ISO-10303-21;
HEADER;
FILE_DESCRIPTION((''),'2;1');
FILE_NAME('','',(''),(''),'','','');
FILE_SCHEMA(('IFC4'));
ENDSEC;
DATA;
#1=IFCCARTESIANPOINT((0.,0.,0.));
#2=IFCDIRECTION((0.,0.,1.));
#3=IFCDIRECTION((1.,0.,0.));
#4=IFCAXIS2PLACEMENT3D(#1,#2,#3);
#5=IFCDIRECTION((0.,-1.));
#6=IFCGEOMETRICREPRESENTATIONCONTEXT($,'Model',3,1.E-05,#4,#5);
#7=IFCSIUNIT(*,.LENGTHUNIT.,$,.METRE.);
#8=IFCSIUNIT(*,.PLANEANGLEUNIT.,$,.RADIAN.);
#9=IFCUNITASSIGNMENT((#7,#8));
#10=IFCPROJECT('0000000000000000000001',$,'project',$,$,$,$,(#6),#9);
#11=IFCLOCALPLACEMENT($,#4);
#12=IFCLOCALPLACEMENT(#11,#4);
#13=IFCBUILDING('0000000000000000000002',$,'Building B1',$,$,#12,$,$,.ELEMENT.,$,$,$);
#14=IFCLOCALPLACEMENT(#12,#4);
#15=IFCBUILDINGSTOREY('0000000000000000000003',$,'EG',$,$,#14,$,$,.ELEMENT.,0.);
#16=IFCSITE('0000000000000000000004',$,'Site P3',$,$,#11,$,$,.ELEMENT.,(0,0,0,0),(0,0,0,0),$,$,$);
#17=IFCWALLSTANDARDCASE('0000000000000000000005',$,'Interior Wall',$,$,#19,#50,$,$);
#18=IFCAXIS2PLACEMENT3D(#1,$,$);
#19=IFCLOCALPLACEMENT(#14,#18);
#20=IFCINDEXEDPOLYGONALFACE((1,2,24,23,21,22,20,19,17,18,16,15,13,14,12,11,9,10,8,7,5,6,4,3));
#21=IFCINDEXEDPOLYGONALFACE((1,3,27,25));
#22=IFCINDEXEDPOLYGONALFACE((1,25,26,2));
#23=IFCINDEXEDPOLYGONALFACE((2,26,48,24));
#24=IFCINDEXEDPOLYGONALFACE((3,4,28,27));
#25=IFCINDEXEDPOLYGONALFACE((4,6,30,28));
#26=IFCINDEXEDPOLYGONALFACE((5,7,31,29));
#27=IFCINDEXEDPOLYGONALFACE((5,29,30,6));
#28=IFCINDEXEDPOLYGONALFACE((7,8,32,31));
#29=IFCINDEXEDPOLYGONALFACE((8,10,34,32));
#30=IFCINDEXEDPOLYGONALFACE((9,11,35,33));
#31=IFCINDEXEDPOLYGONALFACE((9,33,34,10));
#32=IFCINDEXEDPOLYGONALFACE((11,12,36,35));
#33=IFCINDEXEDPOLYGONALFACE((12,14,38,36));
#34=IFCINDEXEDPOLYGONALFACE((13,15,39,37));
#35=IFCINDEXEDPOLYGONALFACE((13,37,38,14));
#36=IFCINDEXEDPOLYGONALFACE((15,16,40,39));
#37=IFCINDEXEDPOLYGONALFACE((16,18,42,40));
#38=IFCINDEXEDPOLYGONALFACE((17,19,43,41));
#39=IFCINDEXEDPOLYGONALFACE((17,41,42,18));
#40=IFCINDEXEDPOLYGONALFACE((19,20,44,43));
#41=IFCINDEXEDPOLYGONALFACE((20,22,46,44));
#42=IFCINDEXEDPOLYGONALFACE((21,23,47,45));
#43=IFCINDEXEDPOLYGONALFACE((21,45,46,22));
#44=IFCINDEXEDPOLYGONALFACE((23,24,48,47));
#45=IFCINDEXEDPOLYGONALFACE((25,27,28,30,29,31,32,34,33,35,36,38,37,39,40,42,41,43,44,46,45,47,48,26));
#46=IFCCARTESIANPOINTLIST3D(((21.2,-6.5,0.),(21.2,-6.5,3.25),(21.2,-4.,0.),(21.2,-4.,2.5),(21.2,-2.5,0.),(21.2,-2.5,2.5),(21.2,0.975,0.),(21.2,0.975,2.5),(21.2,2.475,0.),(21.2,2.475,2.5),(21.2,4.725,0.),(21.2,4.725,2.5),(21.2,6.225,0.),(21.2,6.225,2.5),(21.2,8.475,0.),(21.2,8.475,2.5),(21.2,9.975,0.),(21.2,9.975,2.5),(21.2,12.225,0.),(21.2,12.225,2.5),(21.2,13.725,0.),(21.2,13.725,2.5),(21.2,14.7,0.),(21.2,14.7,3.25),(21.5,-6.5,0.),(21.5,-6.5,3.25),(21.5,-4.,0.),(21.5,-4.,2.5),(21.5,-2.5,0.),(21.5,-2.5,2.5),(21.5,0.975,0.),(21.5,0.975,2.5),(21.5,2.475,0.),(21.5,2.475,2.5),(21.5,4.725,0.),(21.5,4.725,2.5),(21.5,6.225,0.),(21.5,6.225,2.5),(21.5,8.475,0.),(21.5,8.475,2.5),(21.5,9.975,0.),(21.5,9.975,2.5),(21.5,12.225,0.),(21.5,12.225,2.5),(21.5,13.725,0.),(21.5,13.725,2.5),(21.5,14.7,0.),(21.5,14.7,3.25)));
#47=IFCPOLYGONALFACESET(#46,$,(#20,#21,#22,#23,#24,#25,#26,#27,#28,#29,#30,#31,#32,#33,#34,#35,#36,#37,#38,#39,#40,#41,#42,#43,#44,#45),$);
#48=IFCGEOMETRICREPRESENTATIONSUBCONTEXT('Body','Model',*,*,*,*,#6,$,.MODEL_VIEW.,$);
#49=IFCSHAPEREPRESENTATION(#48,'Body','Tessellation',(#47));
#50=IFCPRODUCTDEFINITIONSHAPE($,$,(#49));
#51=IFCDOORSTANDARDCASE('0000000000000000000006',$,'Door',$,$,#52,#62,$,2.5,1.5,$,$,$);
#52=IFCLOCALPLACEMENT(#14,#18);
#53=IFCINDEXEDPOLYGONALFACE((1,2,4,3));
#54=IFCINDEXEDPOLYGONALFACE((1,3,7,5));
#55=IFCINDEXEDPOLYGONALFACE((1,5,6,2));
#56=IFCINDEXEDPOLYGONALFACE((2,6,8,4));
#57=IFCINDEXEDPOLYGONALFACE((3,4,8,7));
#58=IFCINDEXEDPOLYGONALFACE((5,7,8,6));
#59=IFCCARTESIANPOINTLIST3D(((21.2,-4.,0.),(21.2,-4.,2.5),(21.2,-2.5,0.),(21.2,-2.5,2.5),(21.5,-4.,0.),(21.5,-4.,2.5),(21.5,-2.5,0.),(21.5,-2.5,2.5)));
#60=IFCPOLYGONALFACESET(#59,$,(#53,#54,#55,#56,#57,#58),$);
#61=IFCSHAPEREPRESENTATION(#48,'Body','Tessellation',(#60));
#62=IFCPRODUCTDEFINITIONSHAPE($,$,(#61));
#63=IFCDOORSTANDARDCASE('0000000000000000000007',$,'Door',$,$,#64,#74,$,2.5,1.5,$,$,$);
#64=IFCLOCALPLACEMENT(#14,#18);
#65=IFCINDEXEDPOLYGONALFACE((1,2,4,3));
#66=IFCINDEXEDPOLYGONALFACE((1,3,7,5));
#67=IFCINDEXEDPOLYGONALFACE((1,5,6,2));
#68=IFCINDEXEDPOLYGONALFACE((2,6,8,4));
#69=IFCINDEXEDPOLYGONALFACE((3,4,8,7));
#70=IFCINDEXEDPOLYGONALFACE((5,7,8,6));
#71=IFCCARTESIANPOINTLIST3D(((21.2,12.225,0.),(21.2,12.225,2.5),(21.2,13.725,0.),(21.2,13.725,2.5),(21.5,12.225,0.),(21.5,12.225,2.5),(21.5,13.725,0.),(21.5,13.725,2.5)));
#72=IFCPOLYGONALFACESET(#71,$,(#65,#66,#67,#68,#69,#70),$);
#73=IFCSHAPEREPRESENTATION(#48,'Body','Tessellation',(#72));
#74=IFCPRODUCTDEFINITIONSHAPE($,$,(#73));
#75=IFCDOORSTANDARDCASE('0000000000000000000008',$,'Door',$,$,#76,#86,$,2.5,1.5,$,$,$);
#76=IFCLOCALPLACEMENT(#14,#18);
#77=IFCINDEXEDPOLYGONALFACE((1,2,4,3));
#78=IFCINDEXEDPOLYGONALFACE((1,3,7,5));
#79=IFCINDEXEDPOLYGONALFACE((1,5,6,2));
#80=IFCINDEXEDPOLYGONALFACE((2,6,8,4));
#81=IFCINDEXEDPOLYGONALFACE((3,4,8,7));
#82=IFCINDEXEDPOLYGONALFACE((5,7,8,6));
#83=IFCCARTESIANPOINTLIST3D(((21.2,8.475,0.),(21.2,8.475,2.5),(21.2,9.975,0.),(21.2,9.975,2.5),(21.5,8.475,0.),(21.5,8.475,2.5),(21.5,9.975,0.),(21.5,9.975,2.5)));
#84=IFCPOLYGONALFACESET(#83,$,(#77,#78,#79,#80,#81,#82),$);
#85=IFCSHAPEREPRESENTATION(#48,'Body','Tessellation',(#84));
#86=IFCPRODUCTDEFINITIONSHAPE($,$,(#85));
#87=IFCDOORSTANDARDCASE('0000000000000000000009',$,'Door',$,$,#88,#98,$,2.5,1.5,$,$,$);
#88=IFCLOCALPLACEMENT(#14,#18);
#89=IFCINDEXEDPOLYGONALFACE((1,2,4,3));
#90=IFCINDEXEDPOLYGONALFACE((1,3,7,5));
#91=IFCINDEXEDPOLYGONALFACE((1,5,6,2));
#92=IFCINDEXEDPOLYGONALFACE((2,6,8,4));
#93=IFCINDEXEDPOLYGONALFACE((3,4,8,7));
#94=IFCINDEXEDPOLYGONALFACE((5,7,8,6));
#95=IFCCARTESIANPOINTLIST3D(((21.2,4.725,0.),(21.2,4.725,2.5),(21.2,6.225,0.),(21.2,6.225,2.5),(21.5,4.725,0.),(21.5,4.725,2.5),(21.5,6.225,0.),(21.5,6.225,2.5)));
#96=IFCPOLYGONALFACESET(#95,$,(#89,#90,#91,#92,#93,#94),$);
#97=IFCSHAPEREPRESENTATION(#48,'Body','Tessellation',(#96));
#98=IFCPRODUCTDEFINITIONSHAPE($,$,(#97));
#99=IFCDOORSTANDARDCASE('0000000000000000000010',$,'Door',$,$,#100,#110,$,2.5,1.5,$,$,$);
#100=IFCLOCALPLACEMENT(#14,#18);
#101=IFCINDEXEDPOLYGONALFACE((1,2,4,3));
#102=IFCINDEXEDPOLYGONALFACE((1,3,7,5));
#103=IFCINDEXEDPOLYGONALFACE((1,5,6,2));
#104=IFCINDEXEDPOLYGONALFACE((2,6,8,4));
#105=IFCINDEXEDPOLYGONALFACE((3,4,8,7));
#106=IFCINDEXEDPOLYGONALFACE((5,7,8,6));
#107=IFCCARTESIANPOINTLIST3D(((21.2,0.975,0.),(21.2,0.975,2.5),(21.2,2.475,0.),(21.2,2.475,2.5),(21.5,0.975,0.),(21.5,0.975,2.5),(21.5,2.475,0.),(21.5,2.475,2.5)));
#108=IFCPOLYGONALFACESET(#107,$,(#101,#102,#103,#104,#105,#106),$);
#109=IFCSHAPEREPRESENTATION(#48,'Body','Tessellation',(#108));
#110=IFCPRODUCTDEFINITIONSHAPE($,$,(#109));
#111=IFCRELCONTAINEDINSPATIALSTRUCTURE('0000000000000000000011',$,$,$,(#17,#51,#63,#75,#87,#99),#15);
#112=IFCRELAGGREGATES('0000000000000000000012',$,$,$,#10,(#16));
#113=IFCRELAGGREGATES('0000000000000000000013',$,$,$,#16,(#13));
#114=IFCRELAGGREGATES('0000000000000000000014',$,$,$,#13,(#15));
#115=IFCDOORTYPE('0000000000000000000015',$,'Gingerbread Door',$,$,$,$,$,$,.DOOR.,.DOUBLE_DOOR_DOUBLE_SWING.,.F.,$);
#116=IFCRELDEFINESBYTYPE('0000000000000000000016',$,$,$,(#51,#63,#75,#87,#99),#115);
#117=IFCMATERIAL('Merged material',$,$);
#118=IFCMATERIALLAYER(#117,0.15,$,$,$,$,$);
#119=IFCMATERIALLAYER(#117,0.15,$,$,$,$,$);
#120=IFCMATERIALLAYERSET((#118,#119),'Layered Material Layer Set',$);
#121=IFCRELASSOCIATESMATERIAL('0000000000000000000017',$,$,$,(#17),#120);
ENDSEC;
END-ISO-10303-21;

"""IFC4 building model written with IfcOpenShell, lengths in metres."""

from ifc_helpers import new_model, si_unit, direction, frame, origin_with_axes, place, context, subcontext, project, spatial, polyline, outline, extrude, source, transform, mapped, material, layer, layer_set, layer_usage, type_object, element, fill, save


model = new_model("IFC4")

# Units and contexts
model_context = context("Model", 3, precision=1e-05, world=origin_with_axes(), true_north=direction((0.0, -1.0)))
body_context = subcontext(model_context, "Body", "Model", "MODEL_VIEW")
ifc_project = project(units=[si_unit("LENGTHUNIT", "METRE"), si_unit("PLANEANGLEUNIT", "RADIAN")], contexts=[model_context])

# Site, building, storey
site_placement = place(None, origin_with_axes())
site = spatial("IfcSite", under=ifc_project, at=site_placement, Name="Site P3", CompositionType="ELEMENT", RefLatitude=(0, 0, 0, 0), RefLongitude=(0, 0, 0, 0))
building_placement = place(site_placement, origin_with_axes())
building = spatial("IfcBuilding", under=site, at=building_placement, Name="Building B1", CompositionType="ELEMENT")
storey_placement = place(building_placement, origin_with_axes())
storey = spatial("IfcBuildingStorey", under=building, at=storey_placement, Name="EG", CompositionType="ELEMENT", Elevation=0.0)

# Shared definitions
ifc_material = material(Name="Merged material")

# Wall, openings, doors
ifc_layer_1 = layer(ifc_material, 0.15)
ifc_layer_2 = layer(ifc_material, 0.15)
ifc_layer_set_1 = layer_set([ifc_layer_1, ifc_layer_2], Name="Layered Material Layer Set")
ifc_layer_usage_1 = layer_usage(ifc_layer_set_1, "AXIS2", "POSITIVE", -0.15)
wall_1_placement = place(storey_placement, frame((21.35, 14.7, 0.0), z_axis=(0.0, 0.0, 1.0), x_axis=(0.0, -1.0, 0.0)))
wall_1 = element("IfcWallStandardCase", 1, at=wall_1_placement, inside=storey, material=ifc_layer_usage_1, Name="Interior Wall", context=body_context, shape_type="SweptSolid", body=[
    extrude(outline(polyline([(0.0, 0.15), (21.2, 0.15), (21.2, -0.15), (0.0, -0.15), (0.0, 0.15)])), origin_with_axes(), (0.0, 0.0, 1.0), 3.25),
])
opening_1_placement = place(wall_1_placement, frame((17.2, 0.0, 0.0), z_axis=(0.0, 0.0, 1.0), x_axis=(1.0, 0.0, 0.0)))
opening_1 = element("IfcOpeningStandardCase", 2, at=opening_1_placement, cuts=wall_1, context=body_context, shape_type="SweptSolid", body=[
    extrude(outline(polyline([(0.0, 0.0), (0.0, 1.5), (2.5, 1.5), (2.5, 0.0), (0.0, 0.0)])), frame((0.0, -0.15, 0.0), z_axis=(0.0, 1.0, 0.0), x_axis=(0.0, 0.0, 1.0)), (0.0, 0.0, 1.0), 0.3),
])
opening_2_placement = place(wall_1_placement, frame((0.975, 0.0, 0.0), z_axis=(0.0, 0.0, 1.0), x_axis=(1.0, 0.0, 0.0)))
opening_2 = element("IfcOpeningStandardCase", 3, at=opening_2_placement, cuts=wall_1, context=body_context, shape_type="SweptSolid", body=[
    extrude(outline(polyline([(0.0, 0.0), (0.0, 1.5), (2.5, 1.5), (2.5, 0.0), (0.0, 0.0)])), frame((0.0, -0.15, 0.0), z_axis=(0.0, 1.0, 0.0), x_axis=(0.0, 0.0, 1.0)), (0.0, 0.0, 1.0), 0.3),
])
opening_3_placement = place(wall_1_placement, frame((4.725, 0.0, 0.0), z_axis=(0.0, 0.0, 1.0), x_axis=(1.0, 0.0, 0.0)))
opening_3 = element("IfcOpeningStandardCase", 4, at=opening_3_placement, cuts=wall_1, context=body_context, shape_type="SweptSolid", body=[
    extrude(outline(polyline([(0.0, 0.0), (0.0, 1.5), (2.5, 1.5), (2.5, 0.0), (0.0, 0.0)])), frame((0.0, -0.15, 0.0), z_axis=(0.0, 1.0, 0.0), x_axis=(0.0, 0.0, 1.0)), (0.0, 0.0, 1.0), 0.3),
])
opening_4_placement = place(wall_1_placement, frame((8.475, 0.0, 0.0), z_axis=(0.0, 0.0, 1.0), x_axis=(1.0, 0.0, 0.0)))
opening_4 = element("IfcOpeningStandardCase", 5, at=opening_4_placement, cuts=wall_1, context=body_context, shape_type="SweptSolid", body=[
    extrude(outline(polyline([(0.0, 0.0), (0.0, 1.5), (2.5, 1.5), (2.5, 0.0), (0.0, 0.0)])), frame((0.0, -0.15, 0.0), z_axis=(0.0, 1.0, 0.0), x_axis=(0.0, 0.0, 1.0)), (0.0, 0.0, 1.0), 0.3),
])
opening_5_placement = place(wall_1_placement, frame((12.225, 0.0, 0.0), z_axis=(0.0, 0.0, 1.0), x_axis=(1.0, 0.0, 0.0)))
opening_5 = element("IfcOpeningStandardCase", 6, at=opening_5_placement, cuts=wall_1, context=body_context, shape_type="SweptSolid", body=[
    extrude(outline(polyline([(0.0, 0.0), (0.0, 1.5), (2.5, 1.5), (2.5, 0.0), (0.0, 0.0)])), frame((0.0, -0.15, 0.0), z_axis=(0.0, 1.0, 0.0), x_axis=(0.0, 0.0, 1.0)), (0.0, 0.0, 1.0), 0.3),
])
door_type = type_object("IfcDoorType", Name="Gingerbread Door", OperationType="DOUBLE_DOOR_DOUBLE_SWING", ParameterTakesPrecedence=False, PredefinedType="DOOR")
shared_shape_1 = source(origin_with_axes(), body_context, "Body", "SweptSolid", [
    extrude(outline(polyline([(0.0, 0.0), (0.0, 1.5), (2.5, 1.5), (2.5, 0.0), (0.0, 0.0)])), frame((0.0, -0.15, 0.0), z_axis=(0.0, 1.0, 0.0), x_axis=(0.0, 0.0, 1.0)), (0.0, 0.0, 1.0), 0.3),
])
door_1_placement = place(opening_1_placement, origin_with_axes())
door_1 = element("IfcDoorStandardCase", 7, at=door_1_placement, inside=storey, type_object=door_type, Name="Door", OverallHeight=2.5, OverallWidth=1.5, context=body_context, shape_type="MappedRepresentation", body=[
    mapped(shared_shape_1, transform((0.0, 0.0, 0.0))),
])
fill(opening_1, door_1)
door_2_placement = place(opening_2_placement, origin_with_axes())
door_2 = element("IfcDoorStandardCase", 8, at=door_2_placement, inside=storey, type_object=door_type, Name="Door", OverallHeight=2.5, OverallWidth=1.5, context=body_context, shape_type="MappedRepresentation", body=[
    mapped(shared_shape_1, transform((0.0, 0.0, 0.0))),
])
fill(opening_2, door_2)
door_3_placement = place(opening_3_placement, origin_with_axes())
door_3 = element("IfcDoorStandardCase", 9, at=door_3_placement, inside=storey, type_object=door_type, Name="Door", OverallHeight=2.5, OverallWidth=1.5, context=body_context, shape_type="MappedRepresentation", body=[
    mapped(shared_shape_1, transform((0.0, 0.0, 0.0))),
])
fill(opening_3, door_3)
door_4_placement = place(opening_4_placement, origin_with_axes())
door_4 = element("IfcDoorStandardCase", 10, at=door_4_placement, inside=storey, type_object=door_type, Name="Door", OverallHeight=2.5, OverallWidth=1.5, context=body_context, shape_type="MappedRepresentation", body=[
    mapped(shared_shape_1, transform((0.0, 0.0, 0.0))),
])
fill(opening_4, door_4)
door_5_placement = place(opening_5_placement, origin_with_axes())
door_5 = element("IfcDoorStandardCase", 11, at=door_5_placement, inside=storey, type_object=door_type, Name="Door", OverallHeight=2.5, OverallWidth=1.5, context=body_context, shape_type="MappedRepresentation", body=[
    mapped(shared_shape_1, transform((0.0, 0.0, 0.0))),
])
fill(opening_5, door_5)

save(model, "model.ifc")
